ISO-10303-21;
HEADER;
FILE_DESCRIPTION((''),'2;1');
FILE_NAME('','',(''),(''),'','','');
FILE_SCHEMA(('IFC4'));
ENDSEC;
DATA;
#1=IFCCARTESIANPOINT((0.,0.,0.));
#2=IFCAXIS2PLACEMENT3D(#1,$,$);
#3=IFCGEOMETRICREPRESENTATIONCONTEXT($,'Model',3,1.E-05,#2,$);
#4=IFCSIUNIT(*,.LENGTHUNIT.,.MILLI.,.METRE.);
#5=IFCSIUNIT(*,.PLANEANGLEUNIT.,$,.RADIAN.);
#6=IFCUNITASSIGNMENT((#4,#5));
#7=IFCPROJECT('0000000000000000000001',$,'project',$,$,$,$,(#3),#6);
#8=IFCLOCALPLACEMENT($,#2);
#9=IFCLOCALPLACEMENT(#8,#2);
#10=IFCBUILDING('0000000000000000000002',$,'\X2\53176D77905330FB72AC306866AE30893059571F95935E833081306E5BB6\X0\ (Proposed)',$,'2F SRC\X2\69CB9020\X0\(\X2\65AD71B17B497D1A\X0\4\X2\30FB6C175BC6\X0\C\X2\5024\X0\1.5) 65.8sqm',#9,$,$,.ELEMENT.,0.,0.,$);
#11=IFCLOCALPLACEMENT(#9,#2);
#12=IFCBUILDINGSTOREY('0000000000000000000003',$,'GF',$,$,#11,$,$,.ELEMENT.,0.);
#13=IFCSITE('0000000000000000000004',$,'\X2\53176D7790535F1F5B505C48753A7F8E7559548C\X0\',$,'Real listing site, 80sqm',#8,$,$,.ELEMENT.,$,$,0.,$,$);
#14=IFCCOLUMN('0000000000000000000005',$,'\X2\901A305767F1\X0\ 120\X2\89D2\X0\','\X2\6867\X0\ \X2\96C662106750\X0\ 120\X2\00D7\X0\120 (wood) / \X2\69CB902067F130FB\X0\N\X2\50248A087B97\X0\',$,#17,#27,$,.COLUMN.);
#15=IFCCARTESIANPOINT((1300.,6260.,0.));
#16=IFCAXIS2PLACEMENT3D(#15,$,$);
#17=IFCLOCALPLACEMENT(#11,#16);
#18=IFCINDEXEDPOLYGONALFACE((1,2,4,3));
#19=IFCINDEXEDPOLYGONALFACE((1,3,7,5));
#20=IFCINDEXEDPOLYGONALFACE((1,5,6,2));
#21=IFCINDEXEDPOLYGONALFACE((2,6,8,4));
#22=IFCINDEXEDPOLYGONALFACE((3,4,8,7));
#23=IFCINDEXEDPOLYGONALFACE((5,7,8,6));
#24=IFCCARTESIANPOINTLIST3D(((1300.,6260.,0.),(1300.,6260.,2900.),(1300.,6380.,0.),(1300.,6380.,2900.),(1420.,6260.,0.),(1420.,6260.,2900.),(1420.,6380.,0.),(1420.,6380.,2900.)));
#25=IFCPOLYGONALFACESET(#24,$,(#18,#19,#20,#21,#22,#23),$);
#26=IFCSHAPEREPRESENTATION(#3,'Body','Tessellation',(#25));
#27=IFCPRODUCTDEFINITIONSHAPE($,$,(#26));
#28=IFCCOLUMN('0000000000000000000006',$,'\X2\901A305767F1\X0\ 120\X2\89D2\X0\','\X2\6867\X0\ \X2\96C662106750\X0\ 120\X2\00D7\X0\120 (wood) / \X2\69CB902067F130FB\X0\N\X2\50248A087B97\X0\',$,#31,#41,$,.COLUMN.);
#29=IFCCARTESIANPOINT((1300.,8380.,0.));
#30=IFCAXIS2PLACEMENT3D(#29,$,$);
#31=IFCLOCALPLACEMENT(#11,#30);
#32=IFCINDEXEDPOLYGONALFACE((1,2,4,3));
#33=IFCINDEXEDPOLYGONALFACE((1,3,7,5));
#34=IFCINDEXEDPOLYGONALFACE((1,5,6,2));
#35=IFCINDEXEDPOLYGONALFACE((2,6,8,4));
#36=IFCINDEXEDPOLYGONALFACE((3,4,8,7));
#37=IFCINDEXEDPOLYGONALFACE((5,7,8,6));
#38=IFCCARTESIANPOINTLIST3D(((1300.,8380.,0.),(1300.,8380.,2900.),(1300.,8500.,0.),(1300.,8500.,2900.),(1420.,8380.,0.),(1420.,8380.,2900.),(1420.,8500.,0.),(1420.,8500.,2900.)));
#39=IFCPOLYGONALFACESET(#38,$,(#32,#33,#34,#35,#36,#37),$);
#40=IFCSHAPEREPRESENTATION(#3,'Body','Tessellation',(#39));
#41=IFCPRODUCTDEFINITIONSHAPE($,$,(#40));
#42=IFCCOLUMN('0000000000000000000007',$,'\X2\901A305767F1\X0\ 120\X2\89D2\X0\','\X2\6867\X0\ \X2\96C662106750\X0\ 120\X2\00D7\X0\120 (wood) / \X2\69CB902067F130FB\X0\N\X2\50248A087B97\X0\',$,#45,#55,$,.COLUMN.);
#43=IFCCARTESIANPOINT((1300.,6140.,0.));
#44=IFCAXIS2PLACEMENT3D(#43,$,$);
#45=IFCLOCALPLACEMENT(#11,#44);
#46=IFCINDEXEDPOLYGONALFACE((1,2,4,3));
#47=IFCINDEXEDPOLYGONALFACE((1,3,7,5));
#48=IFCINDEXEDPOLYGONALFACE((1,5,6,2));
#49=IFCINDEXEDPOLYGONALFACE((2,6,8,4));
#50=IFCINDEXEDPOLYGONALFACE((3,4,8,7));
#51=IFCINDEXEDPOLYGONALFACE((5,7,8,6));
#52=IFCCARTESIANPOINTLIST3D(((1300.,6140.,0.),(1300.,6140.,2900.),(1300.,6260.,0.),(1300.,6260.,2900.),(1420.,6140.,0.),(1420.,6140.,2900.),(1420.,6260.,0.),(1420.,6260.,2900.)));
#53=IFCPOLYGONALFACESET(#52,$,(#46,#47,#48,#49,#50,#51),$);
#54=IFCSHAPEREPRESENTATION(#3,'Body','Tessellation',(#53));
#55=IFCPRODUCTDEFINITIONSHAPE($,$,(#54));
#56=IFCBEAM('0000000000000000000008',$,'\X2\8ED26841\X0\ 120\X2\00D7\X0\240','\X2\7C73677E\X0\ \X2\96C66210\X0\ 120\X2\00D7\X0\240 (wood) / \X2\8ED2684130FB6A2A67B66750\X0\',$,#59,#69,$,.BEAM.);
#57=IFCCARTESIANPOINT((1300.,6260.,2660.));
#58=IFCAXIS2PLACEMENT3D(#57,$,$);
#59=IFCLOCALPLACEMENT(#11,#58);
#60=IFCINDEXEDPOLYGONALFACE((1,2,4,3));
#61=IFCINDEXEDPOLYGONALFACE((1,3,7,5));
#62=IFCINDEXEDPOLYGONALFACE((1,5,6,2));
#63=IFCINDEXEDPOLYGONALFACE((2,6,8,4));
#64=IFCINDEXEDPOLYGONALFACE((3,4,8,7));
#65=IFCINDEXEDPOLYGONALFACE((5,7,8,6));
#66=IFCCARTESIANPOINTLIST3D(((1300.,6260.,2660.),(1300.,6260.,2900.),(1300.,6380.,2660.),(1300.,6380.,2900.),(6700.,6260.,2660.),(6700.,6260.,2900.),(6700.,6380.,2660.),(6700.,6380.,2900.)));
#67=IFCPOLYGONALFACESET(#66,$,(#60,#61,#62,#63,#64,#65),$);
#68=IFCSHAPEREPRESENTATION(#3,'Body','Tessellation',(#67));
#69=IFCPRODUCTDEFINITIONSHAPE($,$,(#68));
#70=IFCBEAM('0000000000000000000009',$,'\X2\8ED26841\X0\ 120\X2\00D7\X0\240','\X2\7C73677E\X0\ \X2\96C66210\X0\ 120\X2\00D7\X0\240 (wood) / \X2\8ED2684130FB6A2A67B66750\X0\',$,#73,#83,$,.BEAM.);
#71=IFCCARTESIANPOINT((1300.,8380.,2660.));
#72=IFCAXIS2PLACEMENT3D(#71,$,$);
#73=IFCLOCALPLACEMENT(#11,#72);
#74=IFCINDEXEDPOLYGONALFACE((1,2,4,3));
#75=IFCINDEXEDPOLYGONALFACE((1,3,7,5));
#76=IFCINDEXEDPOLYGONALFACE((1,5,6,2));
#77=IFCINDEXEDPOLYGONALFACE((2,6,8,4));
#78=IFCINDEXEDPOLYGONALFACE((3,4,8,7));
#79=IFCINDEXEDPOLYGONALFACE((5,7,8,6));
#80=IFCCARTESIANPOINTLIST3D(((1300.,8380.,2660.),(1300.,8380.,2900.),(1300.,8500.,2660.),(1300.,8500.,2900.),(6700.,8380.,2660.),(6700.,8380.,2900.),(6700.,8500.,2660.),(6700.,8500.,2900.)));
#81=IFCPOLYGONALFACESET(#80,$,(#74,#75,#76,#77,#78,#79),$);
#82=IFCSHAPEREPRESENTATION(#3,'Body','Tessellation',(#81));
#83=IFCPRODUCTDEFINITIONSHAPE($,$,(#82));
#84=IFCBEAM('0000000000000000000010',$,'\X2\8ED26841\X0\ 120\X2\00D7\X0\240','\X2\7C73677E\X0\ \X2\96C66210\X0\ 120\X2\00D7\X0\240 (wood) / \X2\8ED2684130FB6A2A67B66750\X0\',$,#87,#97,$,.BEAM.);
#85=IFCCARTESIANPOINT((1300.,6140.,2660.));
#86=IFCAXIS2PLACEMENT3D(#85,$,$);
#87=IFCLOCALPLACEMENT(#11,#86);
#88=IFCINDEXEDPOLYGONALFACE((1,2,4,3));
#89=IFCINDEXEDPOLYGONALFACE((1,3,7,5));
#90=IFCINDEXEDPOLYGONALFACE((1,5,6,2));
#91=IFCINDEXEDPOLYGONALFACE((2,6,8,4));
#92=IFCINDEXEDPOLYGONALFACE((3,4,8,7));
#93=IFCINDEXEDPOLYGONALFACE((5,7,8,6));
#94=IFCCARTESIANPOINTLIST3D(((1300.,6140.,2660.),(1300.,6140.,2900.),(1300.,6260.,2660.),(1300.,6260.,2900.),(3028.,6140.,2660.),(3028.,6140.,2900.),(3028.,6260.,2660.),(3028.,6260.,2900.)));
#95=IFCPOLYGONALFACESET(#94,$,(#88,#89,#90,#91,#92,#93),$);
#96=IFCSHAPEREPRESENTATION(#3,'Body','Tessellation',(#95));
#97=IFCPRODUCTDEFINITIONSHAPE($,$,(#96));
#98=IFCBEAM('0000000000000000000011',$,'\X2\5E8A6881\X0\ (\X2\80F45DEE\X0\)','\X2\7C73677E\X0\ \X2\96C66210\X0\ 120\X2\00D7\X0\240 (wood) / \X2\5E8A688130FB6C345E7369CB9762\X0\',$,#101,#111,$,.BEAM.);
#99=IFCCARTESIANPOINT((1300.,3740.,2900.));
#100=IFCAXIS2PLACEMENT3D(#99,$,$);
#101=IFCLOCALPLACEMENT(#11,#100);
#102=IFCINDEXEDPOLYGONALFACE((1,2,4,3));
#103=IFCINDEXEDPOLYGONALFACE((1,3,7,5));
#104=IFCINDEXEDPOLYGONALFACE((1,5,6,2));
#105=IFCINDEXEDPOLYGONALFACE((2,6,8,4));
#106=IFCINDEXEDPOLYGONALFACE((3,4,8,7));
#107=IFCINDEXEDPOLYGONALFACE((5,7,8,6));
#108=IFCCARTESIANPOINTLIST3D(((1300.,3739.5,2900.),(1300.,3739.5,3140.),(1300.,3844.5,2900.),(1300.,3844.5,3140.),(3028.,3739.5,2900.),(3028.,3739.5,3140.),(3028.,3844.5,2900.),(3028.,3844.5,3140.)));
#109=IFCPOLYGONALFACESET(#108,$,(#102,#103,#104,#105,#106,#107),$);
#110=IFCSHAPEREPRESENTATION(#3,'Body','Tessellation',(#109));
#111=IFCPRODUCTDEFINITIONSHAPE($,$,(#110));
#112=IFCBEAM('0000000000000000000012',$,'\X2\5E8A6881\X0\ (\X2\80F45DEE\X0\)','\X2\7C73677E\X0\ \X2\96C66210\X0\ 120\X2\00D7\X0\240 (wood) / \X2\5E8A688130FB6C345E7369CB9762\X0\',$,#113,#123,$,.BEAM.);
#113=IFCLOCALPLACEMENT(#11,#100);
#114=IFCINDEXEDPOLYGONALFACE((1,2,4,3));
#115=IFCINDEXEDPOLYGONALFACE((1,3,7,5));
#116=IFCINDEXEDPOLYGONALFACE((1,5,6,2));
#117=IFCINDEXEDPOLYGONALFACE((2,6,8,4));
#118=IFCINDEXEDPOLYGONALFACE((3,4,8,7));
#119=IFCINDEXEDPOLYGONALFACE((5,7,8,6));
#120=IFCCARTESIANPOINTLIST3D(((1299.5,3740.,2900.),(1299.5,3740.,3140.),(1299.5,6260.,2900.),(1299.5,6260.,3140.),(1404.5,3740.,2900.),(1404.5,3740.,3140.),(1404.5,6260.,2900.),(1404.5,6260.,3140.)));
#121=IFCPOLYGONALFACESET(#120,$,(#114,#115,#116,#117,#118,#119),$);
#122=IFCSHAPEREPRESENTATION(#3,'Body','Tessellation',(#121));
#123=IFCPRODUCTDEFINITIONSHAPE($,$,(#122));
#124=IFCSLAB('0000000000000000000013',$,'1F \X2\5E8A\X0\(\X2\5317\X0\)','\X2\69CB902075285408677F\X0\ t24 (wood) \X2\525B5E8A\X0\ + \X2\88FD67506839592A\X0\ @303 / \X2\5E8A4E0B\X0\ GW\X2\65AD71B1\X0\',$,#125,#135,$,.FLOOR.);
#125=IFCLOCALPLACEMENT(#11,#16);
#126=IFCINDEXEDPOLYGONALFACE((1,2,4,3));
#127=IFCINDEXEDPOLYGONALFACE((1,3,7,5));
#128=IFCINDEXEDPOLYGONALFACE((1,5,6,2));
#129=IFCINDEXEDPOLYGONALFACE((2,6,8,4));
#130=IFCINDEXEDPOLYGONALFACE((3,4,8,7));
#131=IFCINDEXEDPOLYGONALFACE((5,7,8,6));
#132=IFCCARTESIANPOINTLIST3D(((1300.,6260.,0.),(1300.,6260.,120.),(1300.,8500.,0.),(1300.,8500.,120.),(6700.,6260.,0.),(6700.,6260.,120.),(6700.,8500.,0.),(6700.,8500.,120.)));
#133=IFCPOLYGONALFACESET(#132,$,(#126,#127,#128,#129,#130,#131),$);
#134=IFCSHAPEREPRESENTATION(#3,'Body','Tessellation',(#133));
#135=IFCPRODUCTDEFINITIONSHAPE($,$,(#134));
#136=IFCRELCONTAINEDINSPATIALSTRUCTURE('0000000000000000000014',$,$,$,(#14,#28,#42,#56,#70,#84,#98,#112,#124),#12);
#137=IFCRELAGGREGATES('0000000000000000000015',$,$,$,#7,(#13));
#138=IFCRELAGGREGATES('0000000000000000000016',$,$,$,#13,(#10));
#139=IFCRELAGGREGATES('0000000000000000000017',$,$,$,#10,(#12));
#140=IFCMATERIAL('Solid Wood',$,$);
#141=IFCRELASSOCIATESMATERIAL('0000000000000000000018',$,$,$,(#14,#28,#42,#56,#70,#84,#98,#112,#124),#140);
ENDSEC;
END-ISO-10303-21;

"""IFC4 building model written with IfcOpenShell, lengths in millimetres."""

from ifc_helpers import new_model, si_unit, frame, frame_2d, origin, place, context, project, spatial, rectangle, extrude, material, element, save


model = new_model("IFC4")

# Units and contexts
model_context = context("Model", 3, precision=1e-05, world=origin())
ifc_project = project(units=[si_unit("LENGTHUNIT", "METRE", prefix="MILLI"), si_unit("PLANEANGLEUNIT", "RADIAN")], contexts=[model_context])

# Site, building, storey
site_placement = place(None, origin())
site = spatial("IfcSite", under=ifc_project, at=site_placement, Name="北海道弟子屈町美留和", ObjectType="Real listing site, 80sqm", CompositionType="ELEMENT", RefElevation=0.0)
building_placement = place(site_placement, origin())
building = spatial("IfcBuilding", under=site, at=building_placement, Name="北海道・犬と暮らす土間広めの家 (Proposed)", ObjectType="2F SRC構造(断熱等級4・気密C値1.5) 65.8sqm", CompositionType="ELEMENT", ElevationOfRefHeight=0.0, ElevationOfTerrain=0.0)
storey_placement = place(building_placement, origin())
storey = spatial("IfcBuildingStorey", under=building, at=storey_placement, Name="GF", CompositionType="ELEMENT", Elevation=0.0)

# Columns
ifc_material_1 = material(Name="Solid Wood")
column_1_placement = place(storey_placement, frame((1300.0, 6260.0, 0.0)))
element("IfcColumn", 1, at=column_1_placement, inside=storey, material=ifc_material_1, Name="通し柱 120角", Description="桧 集成材 120×120 (wood) / 構造柱・N値計算", PredefinedType="COLUMN", context=model_context, shape_type="SweptSolid", body=[
    extrude(rectangle(XDim=120.0, YDim=120.0, at=frame_2d((60.0, 60.0))), frame((1300.0, 6260.0, 0.0)), (0.0, 0.0, 1.0), 2900.0),
])
column_2_placement = place(storey_placement, frame((1300.0, 8380.0, 0.0)))
element("IfcColumn", 2, at=column_2_placement, inside=storey, material=ifc_material_1, Name="通し柱 120角", Description="桧 集成材 120×120 (wood) / 構造柱・N値計算", PredefinedType="COLUMN", context=model_context, shape_type="SweptSolid", body=[
    extrude(rectangle(XDim=120.0, YDim=120.0, at=frame_2d((60.0, 60.0))), frame((1300.0, 8380.0, 0.0)), (0.0, 0.0, 1.0), 2900.0),
])
column_3_placement = place(storey_placement, frame((1300.0, 6140.0, 0.0)))
element("IfcColumn", 3, at=column_3_placement, inside=storey, material=ifc_material_1, Name="通し柱 120角", Description="桧 集成材 120×120 (wood) / 構造柱・N値計算", PredefinedType="COLUMN", context=model_context, shape_type="SweptSolid", body=[
    extrude(rectangle(XDim=120.0, YDim=120.0, at=frame_2d((60.0, 60.0))), frame((1300.0, 6140.0, 0.0)), (0.0, 0.0, 1.0), 2900.0),
])

# Beams
beam_1_placement = place(storey_placement, frame((1300.0, 6260.0, 2660.0)))
element("IfcBeam", 4, at=beam_1_placement, inside=storey, material=ifc_material_1, Name="軒桁 120×240", Description="米松 集成 120×240 (wood) / 軒桁・横架材", PredefinedType="BEAM", context=model_context, shape_type="SweptSolid", body=[
    extrude(rectangle(XDim=5400.0, YDim=120.0, at=frame_2d((2700.0, 60.0))), frame((1300.0, 6260.0, 2660.0)), (0.0, 0.0, 1.0), 240.0),
])
beam_2_placement = place(storey_placement, frame((1300.0, 8380.0, 2660.0)))
element("IfcBeam", 5, at=beam_2_placement, inside=storey, material=ifc_material_1, Name="軒桁 120×240", Description="米松 集成 120×240 (wood) / 軒桁・横架材", PredefinedType="BEAM", context=model_context, shape_type="SweptSolid", body=[
    extrude(rectangle(XDim=5400.0, YDim=120.0, at=frame_2d((2700.0, 60.0))), frame((1300.0, 8380.0, 2660.0)), (0.0, 0.0, 1.0), 240.0),
])
beam_3_placement = place(storey_placement, frame((1300.0, 6140.0, 2660.0)))
element("IfcBeam", 6, at=beam_3_placement, inside=storey, material=ifc_material_1, Name="軒桁 120×240", Description="米松 集成 120×240 (wood) / 軒桁・横架材", PredefinedType="BEAM", context=model_context, shape_type="SweptSolid", body=[
    extrude(rectangle(XDim=1728.0, YDim=120.0, at=frame_2d((864.0, 60.0))), frame((1300.0, 6140.0, 2660.0)), (0.0, 0.0, 1.0), 240.0),
])
beam_4_placement = place(storey_placement, frame((1300.0, 3740.0, 2900.0)))
element("IfcBeam", 7, at=beam_4_placement, inside=storey, material=ifc_material_1, Name="床梁 (胴差)", Description="米松 集成 120×240 (wood) / 床梁・水平構面", PredefinedType="BEAM", context=model_context, shape_type="SweptSolid", body=[
    extrude(rectangle(XDim=1728.0, YDim=105.0, at=frame_2d((864.0, 52.0))), frame((1300.0, 3740.0, 2900.0)), (0.0, 0.0, 1.0), 240.0),
])
beam_5_placement = place(storey_placement, frame((1300.0, 3740.0, 2900.0)))
element("IfcBeam", 8, at=beam_5_placement, inside=storey, material=ifc_material_1, Name="床梁 (胴差)", Description="米松 集成 120×240 (wood) / 床梁・水平構面", PredefinedType="BEAM", context=model_context, shape_type="SweptSolid", body=[
    extrude(rectangle(XDim=105.0, YDim=2520.0, at=frame_2d((52.0, 1260.0))), frame((1300.0, 3740.0, 2900.0)), (0.0, 0.0, 1.0), 240.0),
])

# Slab
slab_placement = place(storey_placement, frame((1300.0, 6260.0, 0.0)))
element("IfcSlab", 9, at=slab_placement, inside=storey, material=ifc_material_1, Name="1F 床(北)", Description="構造用合板 t24 (wood) 剛床 + 製材根太 @303 / 床下 GW断熱", PredefinedType="FLOOR", context=model_context, shape_type="SweptSolid", body=[
    extrude(rectangle(XDim=5400.0, YDim=2240.0, at=frame_2d((2700.0, 1120.0))), frame((1300.0, 6260.0, 0.0)), (0.0, 0.0, 1.0), 120.0),
])

save(model, "model.ifc")
